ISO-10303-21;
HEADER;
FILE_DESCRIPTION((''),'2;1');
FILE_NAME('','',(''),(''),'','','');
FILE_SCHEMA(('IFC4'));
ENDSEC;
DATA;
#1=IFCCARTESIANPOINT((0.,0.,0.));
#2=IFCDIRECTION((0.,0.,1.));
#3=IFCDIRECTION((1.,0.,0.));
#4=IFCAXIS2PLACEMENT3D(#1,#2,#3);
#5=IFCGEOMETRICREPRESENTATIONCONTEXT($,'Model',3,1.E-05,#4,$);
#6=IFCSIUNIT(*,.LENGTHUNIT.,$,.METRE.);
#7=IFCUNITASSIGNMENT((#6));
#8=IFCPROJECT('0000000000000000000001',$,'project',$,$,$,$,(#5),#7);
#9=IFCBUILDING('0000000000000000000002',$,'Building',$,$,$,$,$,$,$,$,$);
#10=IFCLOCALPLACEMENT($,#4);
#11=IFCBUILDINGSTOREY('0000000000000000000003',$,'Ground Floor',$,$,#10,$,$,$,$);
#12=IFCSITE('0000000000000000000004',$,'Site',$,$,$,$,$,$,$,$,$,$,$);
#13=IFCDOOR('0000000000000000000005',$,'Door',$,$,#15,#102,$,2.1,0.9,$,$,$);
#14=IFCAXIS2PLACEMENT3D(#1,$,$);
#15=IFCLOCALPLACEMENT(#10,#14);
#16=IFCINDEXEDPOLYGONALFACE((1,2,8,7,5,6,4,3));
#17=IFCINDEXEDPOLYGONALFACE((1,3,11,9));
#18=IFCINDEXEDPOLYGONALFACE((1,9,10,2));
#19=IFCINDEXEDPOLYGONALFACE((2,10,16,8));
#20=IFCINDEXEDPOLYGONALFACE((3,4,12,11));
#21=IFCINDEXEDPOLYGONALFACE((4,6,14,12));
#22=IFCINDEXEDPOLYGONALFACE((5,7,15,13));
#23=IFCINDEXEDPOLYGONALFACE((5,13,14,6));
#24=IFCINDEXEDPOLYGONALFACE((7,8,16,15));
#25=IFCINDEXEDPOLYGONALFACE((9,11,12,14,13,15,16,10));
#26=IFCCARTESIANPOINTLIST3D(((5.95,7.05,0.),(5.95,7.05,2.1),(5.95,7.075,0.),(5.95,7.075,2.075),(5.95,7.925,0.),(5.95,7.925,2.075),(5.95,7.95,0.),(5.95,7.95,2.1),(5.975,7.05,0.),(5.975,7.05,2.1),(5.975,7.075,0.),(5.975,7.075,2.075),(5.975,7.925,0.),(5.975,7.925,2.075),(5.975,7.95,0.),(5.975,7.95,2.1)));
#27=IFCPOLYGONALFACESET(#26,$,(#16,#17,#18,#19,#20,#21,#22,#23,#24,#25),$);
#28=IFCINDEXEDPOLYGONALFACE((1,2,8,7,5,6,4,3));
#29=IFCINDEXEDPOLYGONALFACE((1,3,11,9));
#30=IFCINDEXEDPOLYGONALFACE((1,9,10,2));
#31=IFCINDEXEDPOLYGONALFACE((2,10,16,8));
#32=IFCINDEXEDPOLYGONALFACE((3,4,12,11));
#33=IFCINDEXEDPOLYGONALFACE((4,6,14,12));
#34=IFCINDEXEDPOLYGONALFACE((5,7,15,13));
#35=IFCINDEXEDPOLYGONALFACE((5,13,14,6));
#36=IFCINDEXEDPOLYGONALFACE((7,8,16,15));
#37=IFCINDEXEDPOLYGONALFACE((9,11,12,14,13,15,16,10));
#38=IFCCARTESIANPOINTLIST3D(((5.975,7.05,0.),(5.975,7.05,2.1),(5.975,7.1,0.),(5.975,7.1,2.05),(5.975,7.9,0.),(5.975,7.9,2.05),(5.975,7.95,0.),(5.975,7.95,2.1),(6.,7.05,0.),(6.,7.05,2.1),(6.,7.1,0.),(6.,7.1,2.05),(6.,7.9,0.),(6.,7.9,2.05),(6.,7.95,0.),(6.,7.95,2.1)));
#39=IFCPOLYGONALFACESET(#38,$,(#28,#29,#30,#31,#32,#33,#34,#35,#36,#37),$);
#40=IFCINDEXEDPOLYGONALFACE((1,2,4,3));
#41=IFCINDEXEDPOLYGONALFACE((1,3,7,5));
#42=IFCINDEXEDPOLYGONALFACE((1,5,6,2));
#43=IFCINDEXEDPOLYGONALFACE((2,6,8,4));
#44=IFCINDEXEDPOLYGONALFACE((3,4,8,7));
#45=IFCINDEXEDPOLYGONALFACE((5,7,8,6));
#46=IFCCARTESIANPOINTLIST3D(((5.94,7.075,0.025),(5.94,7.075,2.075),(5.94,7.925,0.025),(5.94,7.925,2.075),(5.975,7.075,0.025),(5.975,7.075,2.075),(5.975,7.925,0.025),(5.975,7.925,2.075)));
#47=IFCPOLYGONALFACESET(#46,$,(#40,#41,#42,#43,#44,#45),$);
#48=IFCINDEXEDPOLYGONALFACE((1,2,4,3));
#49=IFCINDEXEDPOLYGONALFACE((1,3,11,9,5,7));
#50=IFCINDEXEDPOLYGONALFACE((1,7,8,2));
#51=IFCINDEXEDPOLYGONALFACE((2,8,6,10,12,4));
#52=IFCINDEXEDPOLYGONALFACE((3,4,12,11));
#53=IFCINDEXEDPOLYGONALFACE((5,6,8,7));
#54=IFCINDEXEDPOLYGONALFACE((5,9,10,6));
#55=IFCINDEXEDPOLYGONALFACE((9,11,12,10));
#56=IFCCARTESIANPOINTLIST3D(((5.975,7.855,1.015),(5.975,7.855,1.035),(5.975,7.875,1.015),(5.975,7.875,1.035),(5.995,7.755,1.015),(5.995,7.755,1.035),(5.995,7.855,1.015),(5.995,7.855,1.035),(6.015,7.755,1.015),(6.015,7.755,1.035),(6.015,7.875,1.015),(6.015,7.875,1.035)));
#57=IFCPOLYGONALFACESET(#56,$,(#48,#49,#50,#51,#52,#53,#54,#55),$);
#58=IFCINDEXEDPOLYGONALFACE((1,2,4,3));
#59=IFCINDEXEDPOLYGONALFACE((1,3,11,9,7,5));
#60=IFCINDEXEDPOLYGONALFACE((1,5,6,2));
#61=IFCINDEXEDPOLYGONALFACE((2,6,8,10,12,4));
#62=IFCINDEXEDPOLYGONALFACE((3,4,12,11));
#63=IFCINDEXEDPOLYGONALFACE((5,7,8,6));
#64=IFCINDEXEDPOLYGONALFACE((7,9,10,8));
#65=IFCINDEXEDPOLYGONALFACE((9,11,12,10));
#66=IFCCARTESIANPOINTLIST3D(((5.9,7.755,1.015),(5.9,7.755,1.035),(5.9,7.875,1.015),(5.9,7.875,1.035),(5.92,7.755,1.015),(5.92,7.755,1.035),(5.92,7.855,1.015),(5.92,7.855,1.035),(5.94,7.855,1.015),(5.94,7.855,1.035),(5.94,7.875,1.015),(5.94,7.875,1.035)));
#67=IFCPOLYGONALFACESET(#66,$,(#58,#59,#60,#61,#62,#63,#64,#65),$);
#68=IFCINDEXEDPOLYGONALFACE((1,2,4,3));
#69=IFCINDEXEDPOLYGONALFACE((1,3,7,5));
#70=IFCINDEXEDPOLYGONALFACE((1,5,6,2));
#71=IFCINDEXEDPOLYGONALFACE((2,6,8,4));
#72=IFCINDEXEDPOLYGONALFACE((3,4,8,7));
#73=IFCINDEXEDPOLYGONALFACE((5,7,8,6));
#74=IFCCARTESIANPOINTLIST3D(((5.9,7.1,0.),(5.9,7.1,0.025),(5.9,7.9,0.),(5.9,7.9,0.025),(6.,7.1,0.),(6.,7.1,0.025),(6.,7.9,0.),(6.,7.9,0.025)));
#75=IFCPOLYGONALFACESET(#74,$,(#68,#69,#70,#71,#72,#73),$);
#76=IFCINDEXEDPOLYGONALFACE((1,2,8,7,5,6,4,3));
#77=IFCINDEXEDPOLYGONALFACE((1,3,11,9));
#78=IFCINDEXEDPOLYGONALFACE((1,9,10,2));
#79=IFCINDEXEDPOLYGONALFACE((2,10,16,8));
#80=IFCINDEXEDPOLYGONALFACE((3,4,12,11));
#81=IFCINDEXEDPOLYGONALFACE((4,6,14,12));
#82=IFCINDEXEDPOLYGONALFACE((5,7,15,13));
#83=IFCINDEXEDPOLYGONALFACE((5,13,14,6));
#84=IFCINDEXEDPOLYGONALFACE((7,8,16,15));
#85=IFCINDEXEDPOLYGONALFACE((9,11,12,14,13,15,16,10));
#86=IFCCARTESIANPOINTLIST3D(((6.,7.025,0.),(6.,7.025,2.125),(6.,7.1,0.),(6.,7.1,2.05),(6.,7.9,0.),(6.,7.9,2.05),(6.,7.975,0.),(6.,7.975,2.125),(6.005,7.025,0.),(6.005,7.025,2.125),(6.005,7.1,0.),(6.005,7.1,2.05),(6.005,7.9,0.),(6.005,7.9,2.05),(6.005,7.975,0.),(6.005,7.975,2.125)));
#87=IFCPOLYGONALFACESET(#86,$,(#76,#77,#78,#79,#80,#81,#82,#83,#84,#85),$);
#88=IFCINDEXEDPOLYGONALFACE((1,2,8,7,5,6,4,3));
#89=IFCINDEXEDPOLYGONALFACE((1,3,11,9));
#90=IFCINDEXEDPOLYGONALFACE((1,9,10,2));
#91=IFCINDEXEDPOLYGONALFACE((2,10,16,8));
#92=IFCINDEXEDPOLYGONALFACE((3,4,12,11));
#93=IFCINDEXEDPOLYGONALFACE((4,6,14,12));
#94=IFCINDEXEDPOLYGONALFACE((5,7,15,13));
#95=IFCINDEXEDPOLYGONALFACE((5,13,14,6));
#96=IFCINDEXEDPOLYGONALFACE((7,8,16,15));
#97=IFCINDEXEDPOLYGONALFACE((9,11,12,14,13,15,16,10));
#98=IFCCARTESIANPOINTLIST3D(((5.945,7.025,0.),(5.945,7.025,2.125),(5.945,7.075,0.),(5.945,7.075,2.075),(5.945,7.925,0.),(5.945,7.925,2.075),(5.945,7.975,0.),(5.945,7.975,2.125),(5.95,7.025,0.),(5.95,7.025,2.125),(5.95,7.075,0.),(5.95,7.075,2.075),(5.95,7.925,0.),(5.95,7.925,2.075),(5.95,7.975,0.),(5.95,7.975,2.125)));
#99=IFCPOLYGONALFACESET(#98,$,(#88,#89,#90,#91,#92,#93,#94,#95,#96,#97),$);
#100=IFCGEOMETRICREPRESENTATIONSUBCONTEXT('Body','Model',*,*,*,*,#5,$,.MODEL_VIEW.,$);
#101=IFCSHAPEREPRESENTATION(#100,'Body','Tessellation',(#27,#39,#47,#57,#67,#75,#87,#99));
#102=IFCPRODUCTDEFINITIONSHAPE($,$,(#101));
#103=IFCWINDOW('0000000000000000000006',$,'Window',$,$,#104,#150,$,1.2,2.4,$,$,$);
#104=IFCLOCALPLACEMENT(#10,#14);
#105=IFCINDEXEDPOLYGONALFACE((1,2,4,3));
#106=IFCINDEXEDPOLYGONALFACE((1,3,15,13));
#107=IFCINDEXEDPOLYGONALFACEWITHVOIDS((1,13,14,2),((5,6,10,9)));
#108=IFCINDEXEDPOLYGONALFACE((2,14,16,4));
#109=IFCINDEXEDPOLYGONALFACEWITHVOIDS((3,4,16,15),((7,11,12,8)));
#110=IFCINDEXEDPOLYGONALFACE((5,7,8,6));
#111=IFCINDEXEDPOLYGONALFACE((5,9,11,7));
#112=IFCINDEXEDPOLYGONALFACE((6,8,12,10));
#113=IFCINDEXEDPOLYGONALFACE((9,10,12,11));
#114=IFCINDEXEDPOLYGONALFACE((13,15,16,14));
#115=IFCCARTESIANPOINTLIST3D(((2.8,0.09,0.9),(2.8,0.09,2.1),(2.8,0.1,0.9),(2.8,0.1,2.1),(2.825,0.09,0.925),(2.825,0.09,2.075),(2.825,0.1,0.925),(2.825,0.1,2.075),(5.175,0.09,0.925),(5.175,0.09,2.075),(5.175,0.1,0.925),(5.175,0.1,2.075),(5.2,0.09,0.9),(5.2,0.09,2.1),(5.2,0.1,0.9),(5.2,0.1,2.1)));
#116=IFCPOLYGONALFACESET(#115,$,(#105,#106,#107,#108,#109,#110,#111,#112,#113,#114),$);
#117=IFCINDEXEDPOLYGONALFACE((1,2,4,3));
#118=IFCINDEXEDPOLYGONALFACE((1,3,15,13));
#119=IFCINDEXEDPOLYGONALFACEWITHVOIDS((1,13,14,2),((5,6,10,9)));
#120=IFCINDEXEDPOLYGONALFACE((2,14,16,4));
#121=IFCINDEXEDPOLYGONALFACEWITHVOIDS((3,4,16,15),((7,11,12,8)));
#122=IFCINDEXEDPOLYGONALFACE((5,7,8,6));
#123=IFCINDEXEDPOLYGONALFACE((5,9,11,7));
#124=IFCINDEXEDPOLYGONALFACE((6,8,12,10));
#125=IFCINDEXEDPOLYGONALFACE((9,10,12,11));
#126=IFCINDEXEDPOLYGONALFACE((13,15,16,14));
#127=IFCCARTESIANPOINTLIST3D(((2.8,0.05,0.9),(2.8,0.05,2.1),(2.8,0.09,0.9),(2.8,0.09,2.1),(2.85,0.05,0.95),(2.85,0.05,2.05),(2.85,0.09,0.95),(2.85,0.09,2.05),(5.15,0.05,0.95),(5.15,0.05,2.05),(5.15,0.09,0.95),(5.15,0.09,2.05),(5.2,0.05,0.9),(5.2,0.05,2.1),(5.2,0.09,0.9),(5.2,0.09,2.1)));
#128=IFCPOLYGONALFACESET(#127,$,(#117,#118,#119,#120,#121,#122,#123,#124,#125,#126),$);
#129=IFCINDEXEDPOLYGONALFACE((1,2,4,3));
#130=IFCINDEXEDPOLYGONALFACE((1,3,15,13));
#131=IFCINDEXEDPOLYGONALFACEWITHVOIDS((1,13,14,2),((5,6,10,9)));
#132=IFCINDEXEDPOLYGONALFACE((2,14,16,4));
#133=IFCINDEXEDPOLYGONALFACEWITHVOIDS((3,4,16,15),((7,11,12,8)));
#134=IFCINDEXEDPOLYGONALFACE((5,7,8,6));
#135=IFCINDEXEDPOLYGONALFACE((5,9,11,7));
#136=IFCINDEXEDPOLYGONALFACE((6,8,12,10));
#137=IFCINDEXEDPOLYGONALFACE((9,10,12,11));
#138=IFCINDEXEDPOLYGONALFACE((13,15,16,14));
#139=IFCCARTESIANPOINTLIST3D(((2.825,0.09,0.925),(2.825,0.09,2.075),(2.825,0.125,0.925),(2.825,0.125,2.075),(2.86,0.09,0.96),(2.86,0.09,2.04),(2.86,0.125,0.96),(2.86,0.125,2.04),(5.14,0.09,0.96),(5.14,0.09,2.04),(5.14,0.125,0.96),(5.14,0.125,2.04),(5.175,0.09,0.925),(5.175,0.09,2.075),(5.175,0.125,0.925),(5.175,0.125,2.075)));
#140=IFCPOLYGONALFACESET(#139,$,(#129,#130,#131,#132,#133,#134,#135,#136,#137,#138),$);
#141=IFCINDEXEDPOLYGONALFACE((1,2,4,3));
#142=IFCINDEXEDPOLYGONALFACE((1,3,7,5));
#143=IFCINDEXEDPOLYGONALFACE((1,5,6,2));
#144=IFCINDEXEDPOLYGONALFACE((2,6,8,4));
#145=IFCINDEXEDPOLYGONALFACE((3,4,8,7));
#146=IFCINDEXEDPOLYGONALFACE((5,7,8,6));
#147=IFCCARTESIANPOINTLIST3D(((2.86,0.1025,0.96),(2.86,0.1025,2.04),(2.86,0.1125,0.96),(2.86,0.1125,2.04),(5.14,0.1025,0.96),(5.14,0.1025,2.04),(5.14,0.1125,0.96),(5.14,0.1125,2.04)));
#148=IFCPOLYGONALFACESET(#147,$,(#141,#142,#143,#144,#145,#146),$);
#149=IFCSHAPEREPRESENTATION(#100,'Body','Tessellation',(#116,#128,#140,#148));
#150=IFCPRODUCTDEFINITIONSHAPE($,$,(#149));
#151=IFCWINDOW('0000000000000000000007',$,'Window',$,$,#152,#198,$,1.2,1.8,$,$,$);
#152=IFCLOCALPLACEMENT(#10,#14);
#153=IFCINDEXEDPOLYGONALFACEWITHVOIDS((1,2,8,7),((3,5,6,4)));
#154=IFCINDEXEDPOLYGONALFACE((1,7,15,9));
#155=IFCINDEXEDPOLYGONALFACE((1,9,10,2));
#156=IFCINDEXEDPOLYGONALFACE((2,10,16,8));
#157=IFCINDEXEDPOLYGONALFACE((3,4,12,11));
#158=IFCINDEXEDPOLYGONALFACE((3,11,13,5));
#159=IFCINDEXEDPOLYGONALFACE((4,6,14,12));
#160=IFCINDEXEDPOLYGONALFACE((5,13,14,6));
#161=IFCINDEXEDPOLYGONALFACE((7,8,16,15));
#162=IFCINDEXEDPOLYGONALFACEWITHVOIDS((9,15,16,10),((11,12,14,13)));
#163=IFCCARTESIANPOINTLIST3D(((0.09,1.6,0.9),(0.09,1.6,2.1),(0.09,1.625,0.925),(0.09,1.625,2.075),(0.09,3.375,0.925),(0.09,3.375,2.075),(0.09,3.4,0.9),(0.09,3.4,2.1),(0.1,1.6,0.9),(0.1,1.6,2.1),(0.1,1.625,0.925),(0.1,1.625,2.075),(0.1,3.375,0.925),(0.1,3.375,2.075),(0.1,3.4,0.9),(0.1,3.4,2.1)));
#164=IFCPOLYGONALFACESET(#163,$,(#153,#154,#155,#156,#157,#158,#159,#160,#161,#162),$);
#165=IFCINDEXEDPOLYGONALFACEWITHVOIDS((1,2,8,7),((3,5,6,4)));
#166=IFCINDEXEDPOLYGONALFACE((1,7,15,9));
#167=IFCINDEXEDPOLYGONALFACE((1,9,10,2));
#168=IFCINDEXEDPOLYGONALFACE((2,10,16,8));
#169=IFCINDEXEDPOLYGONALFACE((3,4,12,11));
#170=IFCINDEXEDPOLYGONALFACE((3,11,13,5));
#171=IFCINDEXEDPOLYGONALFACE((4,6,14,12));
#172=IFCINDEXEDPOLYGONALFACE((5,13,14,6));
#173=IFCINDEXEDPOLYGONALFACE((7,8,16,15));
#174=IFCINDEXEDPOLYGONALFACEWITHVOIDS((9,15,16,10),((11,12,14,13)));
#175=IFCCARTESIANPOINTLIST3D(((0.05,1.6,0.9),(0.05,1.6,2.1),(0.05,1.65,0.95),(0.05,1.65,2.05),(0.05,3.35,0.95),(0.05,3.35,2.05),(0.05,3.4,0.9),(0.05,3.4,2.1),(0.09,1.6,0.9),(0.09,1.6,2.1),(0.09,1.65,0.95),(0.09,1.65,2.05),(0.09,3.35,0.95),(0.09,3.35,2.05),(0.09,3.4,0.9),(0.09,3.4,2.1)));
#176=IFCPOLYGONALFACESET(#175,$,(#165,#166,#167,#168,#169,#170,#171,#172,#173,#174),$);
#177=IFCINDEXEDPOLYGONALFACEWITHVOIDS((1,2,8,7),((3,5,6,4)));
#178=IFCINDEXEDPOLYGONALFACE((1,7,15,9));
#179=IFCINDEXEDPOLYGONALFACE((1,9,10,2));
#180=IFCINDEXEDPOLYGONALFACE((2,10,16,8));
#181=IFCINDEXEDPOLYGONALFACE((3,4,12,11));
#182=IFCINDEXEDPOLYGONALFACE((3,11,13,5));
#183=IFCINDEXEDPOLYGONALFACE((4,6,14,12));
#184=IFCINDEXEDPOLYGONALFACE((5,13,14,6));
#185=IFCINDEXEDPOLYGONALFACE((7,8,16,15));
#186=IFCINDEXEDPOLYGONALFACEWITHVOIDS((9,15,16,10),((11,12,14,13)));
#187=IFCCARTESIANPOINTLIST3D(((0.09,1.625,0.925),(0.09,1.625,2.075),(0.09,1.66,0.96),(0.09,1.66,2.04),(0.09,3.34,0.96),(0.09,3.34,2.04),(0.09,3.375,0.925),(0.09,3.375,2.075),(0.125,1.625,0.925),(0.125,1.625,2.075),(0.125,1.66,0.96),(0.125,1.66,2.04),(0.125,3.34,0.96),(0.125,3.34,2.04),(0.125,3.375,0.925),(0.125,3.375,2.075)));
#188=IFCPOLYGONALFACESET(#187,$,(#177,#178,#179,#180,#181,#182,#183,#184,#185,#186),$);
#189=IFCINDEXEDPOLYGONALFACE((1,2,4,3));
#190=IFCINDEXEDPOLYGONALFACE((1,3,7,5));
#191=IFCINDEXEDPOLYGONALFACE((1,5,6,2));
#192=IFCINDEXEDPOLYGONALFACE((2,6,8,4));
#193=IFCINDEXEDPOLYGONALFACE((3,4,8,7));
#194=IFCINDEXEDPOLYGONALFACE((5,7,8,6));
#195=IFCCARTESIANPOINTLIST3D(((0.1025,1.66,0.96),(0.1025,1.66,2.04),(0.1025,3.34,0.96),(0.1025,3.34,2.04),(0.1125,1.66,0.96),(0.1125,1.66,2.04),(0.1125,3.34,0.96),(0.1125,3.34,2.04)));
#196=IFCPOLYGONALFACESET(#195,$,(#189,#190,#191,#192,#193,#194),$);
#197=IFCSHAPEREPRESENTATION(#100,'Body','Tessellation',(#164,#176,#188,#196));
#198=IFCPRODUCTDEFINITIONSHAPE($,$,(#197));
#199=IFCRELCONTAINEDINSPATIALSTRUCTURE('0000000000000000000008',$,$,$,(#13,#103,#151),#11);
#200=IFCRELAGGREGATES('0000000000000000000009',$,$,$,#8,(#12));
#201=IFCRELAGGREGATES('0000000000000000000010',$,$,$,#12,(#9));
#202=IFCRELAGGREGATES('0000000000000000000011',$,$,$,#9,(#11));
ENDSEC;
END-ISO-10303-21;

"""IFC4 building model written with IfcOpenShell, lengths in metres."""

from ifc_helpers import new_model, si_unit, frame, origin_with_axes, place, context, subcontext, project, spatial, line, indexed_curve, outline, extrude, element, save


model = new_model("IFC4")

# Units and contexts
model_context = context("Model", 3, precision=1e-05, world=origin_with_axes())
body_context = subcontext(model_context, "Body", "Model", "MODEL_VIEW")
ifc_project = project(units=[si_unit("LENGTHUNIT", "METRE")], contexts=[model_context])

# Site, building, storey
site = spatial("IfcSite", under=ifc_project, Name="Site")
building = spatial("IfcBuilding", under=site, Name="Building")
storey_placement = place(None, origin_with_axes())
storey = spatial("IfcBuildingStorey", under=building, at=storey_placement, Name="Ground Floor")

# Door
door_1_placement = place(storey_placement, frame((6.0, 7.05, 0.0), z_axis=(0.0, 0.0, 1.0), x_axis=(0.0, 1.0, 0.0)))
element("IfcDoor", 1, at=door_1_placement, inside=storey, Name="Door", OverallHeight=2.1, OverallWidth=0.9, context=body_context, shape_type="SweptSolid", body=[
    extrude(outline(indexed_curve([(0.0, 0.0), (0.0, 2.1), (0.9, 2.1), (0.9, 0.0), (0.875, 0.0), (0.875, 2.075), (0.025, 2.075), (0.025, 0.0)], segments=[line(1, 2, 3, 4, 5, 6, 7, 8, 1)])), frame((0.0, 0.025, 0.0), z_axis=(0.0, -1.0, 0.0), x_axis=(1.0, 0.0, 0.0)), (0.0, 0.0, -1.0), 0.025),
    extrude(outline(indexed_curve([(0.0, 0.0), (0.0, 2.1), (0.9, 2.1), (0.9, 0.0), (0.85, 0.0), (0.85, 2.05), (0.05, 2.05), (0.05, 0.0)], segments=[line(1, 2, 3, 4, 5, 6, 7, 8, 1)])), frame((0.0, 0.0, 0.0), z_axis=(0.0, -1.0, 0.0), x_axis=(1.0, 0.0, 0.0)), (0.0, 0.0, -1.0), 0.025),
    extrude(outline(indexed_curve([(0.0, 0.0), (0.85, 0.0), (0.85, 0.035), (0.0, 0.035)], segments=[line(1, 2, 3, 4, 1)])), frame((0.025, 0.025, 0.025), z_axis=(0.0, 0.0, 1.0), x_axis=(1.0, 0.0, 0.0)), (0.0, 0.0, 1.0), 2.05),
    extrude(outline(indexed_curve([(0.0, 0.0), (0.0, -0.04), (-0.12, -0.04), (-0.12, -0.02), (-0.02, -0.02), (-0.02, 0.0)], segments=[line(1, 2, 3, 4, 5, 6, 1)])), frame((0.825, 0.025, 1.015), z_axis=(0.0, 0.0, 1.0), x_axis=(1.0, 0.0, 0.0)), (0.0, 0.0, 1.0), 0.02),
    extrude(outline(indexed_curve([(0.0, 0.0), (0.0, 0.04), (-0.12, 0.04), (-0.12, 0.02), (-0.02, 0.02), (-0.02, 0.0)], segments=[line(1, 2, 3, 4, 5, 6, 1)])), frame((0.825, 0.06, 1.015), z_axis=(0.0, 0.0, 1.0), x_axis=(1.0, 0.0, 0.0)), (0.0, 0.0, 1.0), 0.02),
    extrude(outline(indexed_curve([(0.0, 0.0), (0.8, 0.0), (0.8, 0.1), (0.0, 0.1)], segments=[line(1, 2, 3, 4, 1)])), frame((0.05, 0.0, 0.0), z_axis=(0.0, 0.0, 1.0), x_axis=(1.0, 0.0, 0.0)), (0.0, 0.0, 1.0), 0.025),
    extrude(outline(indexed_curve([(0.0, 0.0), (0.0, 2.125), (0.95, 2.125), (0.95, 0.0), (0.875, 0.0), (0.875, 2.05), (0.075, 2.05), (0.075, 0.0)], segments=[line(1, 2, 3, 4, 5, 6, 7, 8, 1)])), frame((-0.025, -0.005, 0.0), z_axis=(0.0, -1.0, 0.0), x_axis=(1.0, 0.0, 0.0)), (0.0, 0.0, -1.0), 0.005),
    extrude(outline(indexed_curve([(0.0, 0.0), (0.0, 2.125), (0.95, 2.125), (0.95, 0.0), (0.9, 0.0), (0.9, 2.075), (0.05, 2.075), (0.05, 0.0)], segments=[line(1, 2, 3, 4, 5, 6, 7, 8, 1)])), frame((-0.025, 0.05, 0.0), z_axis=(0.0, -1.0, 0.0), x_axis=(1.0, 0.0, 0.0)), (0.0, 0.0, -1.0), 0.005),
])

# Windows
window_placement = place(storey_placement, frame((2.8, 0.0, 0.9), z_axis=(0.0, 0.0, 1.0), x_axis=(1.0, 0.0, 0.0)))
element("IfcWindow", 2, at=window_placement, inside=storey, Name="Window", OverallHeight=1.2, OverallWidth=2.4, context=body_context, shape_type="SweptSolid", body=[
    extrude(outline(indexed_curve([(0.0, 0.0), (2.4, 0.0), (2.4, 1.2), (0.0, 1.2)], segments=[line(1, 2, 3, 4, 1)]), holes=[indexed_curve([(0.025, 0.025), (2.375, 0.025), (2.375, 1.175), (0.025, 1.175)], segments=[line(1, 2, 3, 4, 1)])]), frame((0.0, 0.09, 0.0), z_axis=(0.0, -1.0, 0.0), x_axis=(1.0, 0.0, 0.0)), (0.0, 0.0, -1.0), 0.01),
    extrude(outline(indexed_curve([(0.0, 0.0), (2.4, 0.0), (2.4, 1.2), (0.0, 1.2)], segments=[line(1, 2, 3, 4, 1)]), holes=[indexed_curve([(0.05, 0.05), (2.35, 0.05), (2.35, 1.15), (0.05, 1.15)], segments=[line(1, 2, 3, 4, 1)])]), frame((0.0, 0.05, 0.0), z_axis=(0.0, -1.0, 0.0), x_axis=(1.0, 0.0, 0.0)), (0.0, 0.0, -1.0), 0.04),
    extrude(outline(indexed_curve([(0.0, 0.0), (2.35, 0.0), (2.35, 1.15), (0.0, 1.15)], segments=[line(1, 2, 3, 4, 1)]), holes=[indexed_curve([(0.035, 0.035), (2.315, 0.035), (2.315, 1.115), (0.035, 1.115)], segments=[line(1, 2, 3, 4, 1)])]), frame((0.025, 0.09, 0.025), z_axis=(0.0, -1.0, 0.0), x_axis=(1.0, 0.0, 0.0)), (0.0, 0.0, -1.0), 0.035),
    extrude(outline(indexed_curve([(0.035, 0.035), (2.315, 0.035), (2.315, 1.115), (0.035, 1.115)], segments=[line(1, 2, 3, 4, 1)])), frame((0.025, 0.1025, 0.025), z_axis=(0.0, -1.0, 0.0), x_axis=(1.0, 0.0, 0.0)), (0.0, 0.0, -1.0), 0.01),
])
for number, where, z_axis, x_axis, name in (
    (3, (0.0, 3.4, 0.9), (0.0, 0.0, 1.0), (0.0, -1.0, 0.0), "Window"),
):
    element("IfcWindow", number, at=place(storey_placement, frame(where, z_axis=z_axis, x_axis=x_axis)), inside=storey, Name=name, OverallHeight=1.2, OverallWidth=1.8, context=body_context, shape_type="SweptSolid", body=[
        extrude(outline(indexed_curve([(0.0, 0.0), (1.8, 0.0), (1.8, 1.2), (0.0, 1.2)], segments=[line(1, 2, 3, 4, 1)]), holes=[indexed_curve([(0.025, 0.025), (1.775, 0.025), (1.775, 1.175), (0.025, 1.175)], segments=[line(1, 2, 3, 4, 1)])]), frame((0.0, 0.09, 0.0), z_axis=(0.0, -1.0, 0.0), x_axis=(1.0, 0.0, 0.0)), (0.0, 0.0, -1.0), 0.01),
        extrude(outline(indexed_curve([(0.0, 0.0), (1.8, 0.0), (1.8, 1.2), (0.0, 1.2)], segments=[line(1, 2, 3, 4, 1)]), holes=[indexed_curve([(0.05, 0.05), (1.75, 0.05), (1.75, 1.15), (0.05, 1.15)], segments=[line(1, 2, 3, 4, 1)])]), frame((0.0, 0.05, 0.0), z_axis=(0.0, -1.0, 0.0), x_axis=(1.0, 0.0, 0.0)), (0.0, 0.0, -1.0), 0.04),
        extrude(outline(indexed_curve([(0.0, 0.0), (1.75, 0.0), (1.75, 1.15), (0.0, 1.15)], segments=[line(1, 2, 3, 4, 1)]), holes=[indexed_curve([(0.035, 0.035), (1.715, 0.035), (1.715, 1.115), (0.035, 1.115)], segments=[line(1, 2, 3, 4, 1)])]), frame((0.025, 0.09, 0.025), z_axis=(0.0, -1.0, 0.0), x_axis=(1.0, 0.0, 0.0)), (0.0, 0.0, -1.0), 0.035),
        extrude(outline(indexed_curve([(0.035, 0.035), (1.715, 0.035), (1.715, 1.115), (0.035, 1.115)], segments=[line(1, 2, 3, 4, 1)])), frame((0.025, 0.1025, 0.025), z_axis=(0.0, -1.0, 0.0), x_axis=(1.0, 0.0, 0.0)), (0.0, 0.0, -1.0), 0.01),
    ])

save(model, "model.ifc")
